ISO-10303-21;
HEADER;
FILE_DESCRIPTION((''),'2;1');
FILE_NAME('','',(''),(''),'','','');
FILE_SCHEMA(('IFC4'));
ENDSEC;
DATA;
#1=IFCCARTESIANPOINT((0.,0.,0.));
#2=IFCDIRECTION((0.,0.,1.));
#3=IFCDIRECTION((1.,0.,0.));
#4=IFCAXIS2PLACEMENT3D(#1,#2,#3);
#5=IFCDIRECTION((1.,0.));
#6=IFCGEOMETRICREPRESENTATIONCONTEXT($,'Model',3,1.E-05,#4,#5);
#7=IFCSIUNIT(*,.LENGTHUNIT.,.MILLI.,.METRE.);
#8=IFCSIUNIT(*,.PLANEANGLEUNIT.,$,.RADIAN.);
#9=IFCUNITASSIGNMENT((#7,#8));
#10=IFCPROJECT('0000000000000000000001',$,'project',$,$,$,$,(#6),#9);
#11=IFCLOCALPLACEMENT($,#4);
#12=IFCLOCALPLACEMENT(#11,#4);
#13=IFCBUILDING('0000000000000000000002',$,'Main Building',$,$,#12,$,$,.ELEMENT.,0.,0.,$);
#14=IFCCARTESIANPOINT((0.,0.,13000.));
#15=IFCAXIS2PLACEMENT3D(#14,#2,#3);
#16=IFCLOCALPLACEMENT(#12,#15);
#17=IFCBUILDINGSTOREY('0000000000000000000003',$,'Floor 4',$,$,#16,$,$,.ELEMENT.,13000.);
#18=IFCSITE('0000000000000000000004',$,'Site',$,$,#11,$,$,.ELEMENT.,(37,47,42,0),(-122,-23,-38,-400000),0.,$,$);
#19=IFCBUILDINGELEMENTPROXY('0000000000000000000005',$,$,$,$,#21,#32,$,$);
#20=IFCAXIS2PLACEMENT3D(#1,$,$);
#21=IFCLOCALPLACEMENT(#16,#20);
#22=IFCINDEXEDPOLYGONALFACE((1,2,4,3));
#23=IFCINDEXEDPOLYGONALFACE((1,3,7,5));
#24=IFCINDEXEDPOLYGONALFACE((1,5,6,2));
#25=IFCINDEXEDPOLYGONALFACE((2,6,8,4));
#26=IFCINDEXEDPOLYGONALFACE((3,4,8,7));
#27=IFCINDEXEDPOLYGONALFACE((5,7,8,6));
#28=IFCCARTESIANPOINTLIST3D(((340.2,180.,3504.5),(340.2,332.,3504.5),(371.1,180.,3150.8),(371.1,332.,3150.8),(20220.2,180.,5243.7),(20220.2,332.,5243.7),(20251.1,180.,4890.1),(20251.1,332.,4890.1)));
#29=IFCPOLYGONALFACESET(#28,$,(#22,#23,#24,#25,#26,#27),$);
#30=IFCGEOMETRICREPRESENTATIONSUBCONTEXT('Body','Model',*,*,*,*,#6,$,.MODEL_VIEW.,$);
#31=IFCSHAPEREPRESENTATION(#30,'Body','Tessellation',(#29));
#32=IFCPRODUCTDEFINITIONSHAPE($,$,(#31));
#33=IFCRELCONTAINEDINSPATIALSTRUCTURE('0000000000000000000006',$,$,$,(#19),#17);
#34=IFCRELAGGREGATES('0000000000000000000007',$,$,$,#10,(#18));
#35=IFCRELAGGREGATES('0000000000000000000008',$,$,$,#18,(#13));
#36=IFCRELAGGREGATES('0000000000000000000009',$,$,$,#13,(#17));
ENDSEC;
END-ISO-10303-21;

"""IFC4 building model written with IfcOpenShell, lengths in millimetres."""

from ifc_helpers import new_model, si_unit, direction, frame, origin_with_axes, origin_2d_with_axis, place, context, subcontext, project, spatial, rectangle, extrude, element, save


model = new_model("IFC4")

# Units and contexts
model_context = context("Model", 3, precision=1e-05, world=origin_with_axes(), true_north=direction((1.0, 0.0)))
body_context = subcontext(model_context, "Body", "Model", "MODEL_VIEW")
ifc_project = project(units=[si_unit("LENGTHUNIT", "METRE", prefix="MILLI"), si_unit("PLANEANGLEUNIT", "RADIAN")], contexts=[model_context])

# Site, building, storey
site_placement = place(None, origin_with_axes())
site = spatial("IfcSite", under=ifc_project, at=site_placement, Name="Site", CompositionType="ELEMENT", RefLatitude=(37, 47, 42, 0), RefLongitude=(-122, -23, -38, -400000), RefElevation=0.0)
building_placement = place(site_placement, origin_with_axes())
building = spatial("IfcBuilding", under=site, at=building_placement, Name="Main Building", CompositionType="ELEMENT", ElevationOfRefHeight=0.0, ElevationOfTerrain=0.0)
storey_placement = place(building_placement, frame((0.0, 0.0, 13000.0), z_axis=(0.0, 0.0, 1.0), x_axis=(1.0, 0.0, 0.0)))
storey = spatial("IfcBuildingStorey", under=building, at=storey_placement, Name="Floor 4", CompositionType="ELEMENT", Elevation=13000.0)

# Building element proxy
proxy_1_placement = place(storey_placement, frame((340.2, 180.0, 3150.8), z_axis=(0.0, 0.0, 1.0), x_axis=(1.0, 0.0, 0.0)))
element("IfcBuildingElementProxy", 1, at=proxy_1_placement, inside=storey, context=body_context, shape_type="SweptSolid", body=[
    extrude(rectangle(XDim=19956.0, YDim=152.0, at=origin_2d_with_axis()), frame((9971.0, 76.0, 869.6), z_axis=(-0.087156, 0.0, 0.996195), x_axis=(0.996195, 0.0, 0.087156)), (0.0, 0.0, 1.0), 355.0),
])

save(model, "model.ifc")
